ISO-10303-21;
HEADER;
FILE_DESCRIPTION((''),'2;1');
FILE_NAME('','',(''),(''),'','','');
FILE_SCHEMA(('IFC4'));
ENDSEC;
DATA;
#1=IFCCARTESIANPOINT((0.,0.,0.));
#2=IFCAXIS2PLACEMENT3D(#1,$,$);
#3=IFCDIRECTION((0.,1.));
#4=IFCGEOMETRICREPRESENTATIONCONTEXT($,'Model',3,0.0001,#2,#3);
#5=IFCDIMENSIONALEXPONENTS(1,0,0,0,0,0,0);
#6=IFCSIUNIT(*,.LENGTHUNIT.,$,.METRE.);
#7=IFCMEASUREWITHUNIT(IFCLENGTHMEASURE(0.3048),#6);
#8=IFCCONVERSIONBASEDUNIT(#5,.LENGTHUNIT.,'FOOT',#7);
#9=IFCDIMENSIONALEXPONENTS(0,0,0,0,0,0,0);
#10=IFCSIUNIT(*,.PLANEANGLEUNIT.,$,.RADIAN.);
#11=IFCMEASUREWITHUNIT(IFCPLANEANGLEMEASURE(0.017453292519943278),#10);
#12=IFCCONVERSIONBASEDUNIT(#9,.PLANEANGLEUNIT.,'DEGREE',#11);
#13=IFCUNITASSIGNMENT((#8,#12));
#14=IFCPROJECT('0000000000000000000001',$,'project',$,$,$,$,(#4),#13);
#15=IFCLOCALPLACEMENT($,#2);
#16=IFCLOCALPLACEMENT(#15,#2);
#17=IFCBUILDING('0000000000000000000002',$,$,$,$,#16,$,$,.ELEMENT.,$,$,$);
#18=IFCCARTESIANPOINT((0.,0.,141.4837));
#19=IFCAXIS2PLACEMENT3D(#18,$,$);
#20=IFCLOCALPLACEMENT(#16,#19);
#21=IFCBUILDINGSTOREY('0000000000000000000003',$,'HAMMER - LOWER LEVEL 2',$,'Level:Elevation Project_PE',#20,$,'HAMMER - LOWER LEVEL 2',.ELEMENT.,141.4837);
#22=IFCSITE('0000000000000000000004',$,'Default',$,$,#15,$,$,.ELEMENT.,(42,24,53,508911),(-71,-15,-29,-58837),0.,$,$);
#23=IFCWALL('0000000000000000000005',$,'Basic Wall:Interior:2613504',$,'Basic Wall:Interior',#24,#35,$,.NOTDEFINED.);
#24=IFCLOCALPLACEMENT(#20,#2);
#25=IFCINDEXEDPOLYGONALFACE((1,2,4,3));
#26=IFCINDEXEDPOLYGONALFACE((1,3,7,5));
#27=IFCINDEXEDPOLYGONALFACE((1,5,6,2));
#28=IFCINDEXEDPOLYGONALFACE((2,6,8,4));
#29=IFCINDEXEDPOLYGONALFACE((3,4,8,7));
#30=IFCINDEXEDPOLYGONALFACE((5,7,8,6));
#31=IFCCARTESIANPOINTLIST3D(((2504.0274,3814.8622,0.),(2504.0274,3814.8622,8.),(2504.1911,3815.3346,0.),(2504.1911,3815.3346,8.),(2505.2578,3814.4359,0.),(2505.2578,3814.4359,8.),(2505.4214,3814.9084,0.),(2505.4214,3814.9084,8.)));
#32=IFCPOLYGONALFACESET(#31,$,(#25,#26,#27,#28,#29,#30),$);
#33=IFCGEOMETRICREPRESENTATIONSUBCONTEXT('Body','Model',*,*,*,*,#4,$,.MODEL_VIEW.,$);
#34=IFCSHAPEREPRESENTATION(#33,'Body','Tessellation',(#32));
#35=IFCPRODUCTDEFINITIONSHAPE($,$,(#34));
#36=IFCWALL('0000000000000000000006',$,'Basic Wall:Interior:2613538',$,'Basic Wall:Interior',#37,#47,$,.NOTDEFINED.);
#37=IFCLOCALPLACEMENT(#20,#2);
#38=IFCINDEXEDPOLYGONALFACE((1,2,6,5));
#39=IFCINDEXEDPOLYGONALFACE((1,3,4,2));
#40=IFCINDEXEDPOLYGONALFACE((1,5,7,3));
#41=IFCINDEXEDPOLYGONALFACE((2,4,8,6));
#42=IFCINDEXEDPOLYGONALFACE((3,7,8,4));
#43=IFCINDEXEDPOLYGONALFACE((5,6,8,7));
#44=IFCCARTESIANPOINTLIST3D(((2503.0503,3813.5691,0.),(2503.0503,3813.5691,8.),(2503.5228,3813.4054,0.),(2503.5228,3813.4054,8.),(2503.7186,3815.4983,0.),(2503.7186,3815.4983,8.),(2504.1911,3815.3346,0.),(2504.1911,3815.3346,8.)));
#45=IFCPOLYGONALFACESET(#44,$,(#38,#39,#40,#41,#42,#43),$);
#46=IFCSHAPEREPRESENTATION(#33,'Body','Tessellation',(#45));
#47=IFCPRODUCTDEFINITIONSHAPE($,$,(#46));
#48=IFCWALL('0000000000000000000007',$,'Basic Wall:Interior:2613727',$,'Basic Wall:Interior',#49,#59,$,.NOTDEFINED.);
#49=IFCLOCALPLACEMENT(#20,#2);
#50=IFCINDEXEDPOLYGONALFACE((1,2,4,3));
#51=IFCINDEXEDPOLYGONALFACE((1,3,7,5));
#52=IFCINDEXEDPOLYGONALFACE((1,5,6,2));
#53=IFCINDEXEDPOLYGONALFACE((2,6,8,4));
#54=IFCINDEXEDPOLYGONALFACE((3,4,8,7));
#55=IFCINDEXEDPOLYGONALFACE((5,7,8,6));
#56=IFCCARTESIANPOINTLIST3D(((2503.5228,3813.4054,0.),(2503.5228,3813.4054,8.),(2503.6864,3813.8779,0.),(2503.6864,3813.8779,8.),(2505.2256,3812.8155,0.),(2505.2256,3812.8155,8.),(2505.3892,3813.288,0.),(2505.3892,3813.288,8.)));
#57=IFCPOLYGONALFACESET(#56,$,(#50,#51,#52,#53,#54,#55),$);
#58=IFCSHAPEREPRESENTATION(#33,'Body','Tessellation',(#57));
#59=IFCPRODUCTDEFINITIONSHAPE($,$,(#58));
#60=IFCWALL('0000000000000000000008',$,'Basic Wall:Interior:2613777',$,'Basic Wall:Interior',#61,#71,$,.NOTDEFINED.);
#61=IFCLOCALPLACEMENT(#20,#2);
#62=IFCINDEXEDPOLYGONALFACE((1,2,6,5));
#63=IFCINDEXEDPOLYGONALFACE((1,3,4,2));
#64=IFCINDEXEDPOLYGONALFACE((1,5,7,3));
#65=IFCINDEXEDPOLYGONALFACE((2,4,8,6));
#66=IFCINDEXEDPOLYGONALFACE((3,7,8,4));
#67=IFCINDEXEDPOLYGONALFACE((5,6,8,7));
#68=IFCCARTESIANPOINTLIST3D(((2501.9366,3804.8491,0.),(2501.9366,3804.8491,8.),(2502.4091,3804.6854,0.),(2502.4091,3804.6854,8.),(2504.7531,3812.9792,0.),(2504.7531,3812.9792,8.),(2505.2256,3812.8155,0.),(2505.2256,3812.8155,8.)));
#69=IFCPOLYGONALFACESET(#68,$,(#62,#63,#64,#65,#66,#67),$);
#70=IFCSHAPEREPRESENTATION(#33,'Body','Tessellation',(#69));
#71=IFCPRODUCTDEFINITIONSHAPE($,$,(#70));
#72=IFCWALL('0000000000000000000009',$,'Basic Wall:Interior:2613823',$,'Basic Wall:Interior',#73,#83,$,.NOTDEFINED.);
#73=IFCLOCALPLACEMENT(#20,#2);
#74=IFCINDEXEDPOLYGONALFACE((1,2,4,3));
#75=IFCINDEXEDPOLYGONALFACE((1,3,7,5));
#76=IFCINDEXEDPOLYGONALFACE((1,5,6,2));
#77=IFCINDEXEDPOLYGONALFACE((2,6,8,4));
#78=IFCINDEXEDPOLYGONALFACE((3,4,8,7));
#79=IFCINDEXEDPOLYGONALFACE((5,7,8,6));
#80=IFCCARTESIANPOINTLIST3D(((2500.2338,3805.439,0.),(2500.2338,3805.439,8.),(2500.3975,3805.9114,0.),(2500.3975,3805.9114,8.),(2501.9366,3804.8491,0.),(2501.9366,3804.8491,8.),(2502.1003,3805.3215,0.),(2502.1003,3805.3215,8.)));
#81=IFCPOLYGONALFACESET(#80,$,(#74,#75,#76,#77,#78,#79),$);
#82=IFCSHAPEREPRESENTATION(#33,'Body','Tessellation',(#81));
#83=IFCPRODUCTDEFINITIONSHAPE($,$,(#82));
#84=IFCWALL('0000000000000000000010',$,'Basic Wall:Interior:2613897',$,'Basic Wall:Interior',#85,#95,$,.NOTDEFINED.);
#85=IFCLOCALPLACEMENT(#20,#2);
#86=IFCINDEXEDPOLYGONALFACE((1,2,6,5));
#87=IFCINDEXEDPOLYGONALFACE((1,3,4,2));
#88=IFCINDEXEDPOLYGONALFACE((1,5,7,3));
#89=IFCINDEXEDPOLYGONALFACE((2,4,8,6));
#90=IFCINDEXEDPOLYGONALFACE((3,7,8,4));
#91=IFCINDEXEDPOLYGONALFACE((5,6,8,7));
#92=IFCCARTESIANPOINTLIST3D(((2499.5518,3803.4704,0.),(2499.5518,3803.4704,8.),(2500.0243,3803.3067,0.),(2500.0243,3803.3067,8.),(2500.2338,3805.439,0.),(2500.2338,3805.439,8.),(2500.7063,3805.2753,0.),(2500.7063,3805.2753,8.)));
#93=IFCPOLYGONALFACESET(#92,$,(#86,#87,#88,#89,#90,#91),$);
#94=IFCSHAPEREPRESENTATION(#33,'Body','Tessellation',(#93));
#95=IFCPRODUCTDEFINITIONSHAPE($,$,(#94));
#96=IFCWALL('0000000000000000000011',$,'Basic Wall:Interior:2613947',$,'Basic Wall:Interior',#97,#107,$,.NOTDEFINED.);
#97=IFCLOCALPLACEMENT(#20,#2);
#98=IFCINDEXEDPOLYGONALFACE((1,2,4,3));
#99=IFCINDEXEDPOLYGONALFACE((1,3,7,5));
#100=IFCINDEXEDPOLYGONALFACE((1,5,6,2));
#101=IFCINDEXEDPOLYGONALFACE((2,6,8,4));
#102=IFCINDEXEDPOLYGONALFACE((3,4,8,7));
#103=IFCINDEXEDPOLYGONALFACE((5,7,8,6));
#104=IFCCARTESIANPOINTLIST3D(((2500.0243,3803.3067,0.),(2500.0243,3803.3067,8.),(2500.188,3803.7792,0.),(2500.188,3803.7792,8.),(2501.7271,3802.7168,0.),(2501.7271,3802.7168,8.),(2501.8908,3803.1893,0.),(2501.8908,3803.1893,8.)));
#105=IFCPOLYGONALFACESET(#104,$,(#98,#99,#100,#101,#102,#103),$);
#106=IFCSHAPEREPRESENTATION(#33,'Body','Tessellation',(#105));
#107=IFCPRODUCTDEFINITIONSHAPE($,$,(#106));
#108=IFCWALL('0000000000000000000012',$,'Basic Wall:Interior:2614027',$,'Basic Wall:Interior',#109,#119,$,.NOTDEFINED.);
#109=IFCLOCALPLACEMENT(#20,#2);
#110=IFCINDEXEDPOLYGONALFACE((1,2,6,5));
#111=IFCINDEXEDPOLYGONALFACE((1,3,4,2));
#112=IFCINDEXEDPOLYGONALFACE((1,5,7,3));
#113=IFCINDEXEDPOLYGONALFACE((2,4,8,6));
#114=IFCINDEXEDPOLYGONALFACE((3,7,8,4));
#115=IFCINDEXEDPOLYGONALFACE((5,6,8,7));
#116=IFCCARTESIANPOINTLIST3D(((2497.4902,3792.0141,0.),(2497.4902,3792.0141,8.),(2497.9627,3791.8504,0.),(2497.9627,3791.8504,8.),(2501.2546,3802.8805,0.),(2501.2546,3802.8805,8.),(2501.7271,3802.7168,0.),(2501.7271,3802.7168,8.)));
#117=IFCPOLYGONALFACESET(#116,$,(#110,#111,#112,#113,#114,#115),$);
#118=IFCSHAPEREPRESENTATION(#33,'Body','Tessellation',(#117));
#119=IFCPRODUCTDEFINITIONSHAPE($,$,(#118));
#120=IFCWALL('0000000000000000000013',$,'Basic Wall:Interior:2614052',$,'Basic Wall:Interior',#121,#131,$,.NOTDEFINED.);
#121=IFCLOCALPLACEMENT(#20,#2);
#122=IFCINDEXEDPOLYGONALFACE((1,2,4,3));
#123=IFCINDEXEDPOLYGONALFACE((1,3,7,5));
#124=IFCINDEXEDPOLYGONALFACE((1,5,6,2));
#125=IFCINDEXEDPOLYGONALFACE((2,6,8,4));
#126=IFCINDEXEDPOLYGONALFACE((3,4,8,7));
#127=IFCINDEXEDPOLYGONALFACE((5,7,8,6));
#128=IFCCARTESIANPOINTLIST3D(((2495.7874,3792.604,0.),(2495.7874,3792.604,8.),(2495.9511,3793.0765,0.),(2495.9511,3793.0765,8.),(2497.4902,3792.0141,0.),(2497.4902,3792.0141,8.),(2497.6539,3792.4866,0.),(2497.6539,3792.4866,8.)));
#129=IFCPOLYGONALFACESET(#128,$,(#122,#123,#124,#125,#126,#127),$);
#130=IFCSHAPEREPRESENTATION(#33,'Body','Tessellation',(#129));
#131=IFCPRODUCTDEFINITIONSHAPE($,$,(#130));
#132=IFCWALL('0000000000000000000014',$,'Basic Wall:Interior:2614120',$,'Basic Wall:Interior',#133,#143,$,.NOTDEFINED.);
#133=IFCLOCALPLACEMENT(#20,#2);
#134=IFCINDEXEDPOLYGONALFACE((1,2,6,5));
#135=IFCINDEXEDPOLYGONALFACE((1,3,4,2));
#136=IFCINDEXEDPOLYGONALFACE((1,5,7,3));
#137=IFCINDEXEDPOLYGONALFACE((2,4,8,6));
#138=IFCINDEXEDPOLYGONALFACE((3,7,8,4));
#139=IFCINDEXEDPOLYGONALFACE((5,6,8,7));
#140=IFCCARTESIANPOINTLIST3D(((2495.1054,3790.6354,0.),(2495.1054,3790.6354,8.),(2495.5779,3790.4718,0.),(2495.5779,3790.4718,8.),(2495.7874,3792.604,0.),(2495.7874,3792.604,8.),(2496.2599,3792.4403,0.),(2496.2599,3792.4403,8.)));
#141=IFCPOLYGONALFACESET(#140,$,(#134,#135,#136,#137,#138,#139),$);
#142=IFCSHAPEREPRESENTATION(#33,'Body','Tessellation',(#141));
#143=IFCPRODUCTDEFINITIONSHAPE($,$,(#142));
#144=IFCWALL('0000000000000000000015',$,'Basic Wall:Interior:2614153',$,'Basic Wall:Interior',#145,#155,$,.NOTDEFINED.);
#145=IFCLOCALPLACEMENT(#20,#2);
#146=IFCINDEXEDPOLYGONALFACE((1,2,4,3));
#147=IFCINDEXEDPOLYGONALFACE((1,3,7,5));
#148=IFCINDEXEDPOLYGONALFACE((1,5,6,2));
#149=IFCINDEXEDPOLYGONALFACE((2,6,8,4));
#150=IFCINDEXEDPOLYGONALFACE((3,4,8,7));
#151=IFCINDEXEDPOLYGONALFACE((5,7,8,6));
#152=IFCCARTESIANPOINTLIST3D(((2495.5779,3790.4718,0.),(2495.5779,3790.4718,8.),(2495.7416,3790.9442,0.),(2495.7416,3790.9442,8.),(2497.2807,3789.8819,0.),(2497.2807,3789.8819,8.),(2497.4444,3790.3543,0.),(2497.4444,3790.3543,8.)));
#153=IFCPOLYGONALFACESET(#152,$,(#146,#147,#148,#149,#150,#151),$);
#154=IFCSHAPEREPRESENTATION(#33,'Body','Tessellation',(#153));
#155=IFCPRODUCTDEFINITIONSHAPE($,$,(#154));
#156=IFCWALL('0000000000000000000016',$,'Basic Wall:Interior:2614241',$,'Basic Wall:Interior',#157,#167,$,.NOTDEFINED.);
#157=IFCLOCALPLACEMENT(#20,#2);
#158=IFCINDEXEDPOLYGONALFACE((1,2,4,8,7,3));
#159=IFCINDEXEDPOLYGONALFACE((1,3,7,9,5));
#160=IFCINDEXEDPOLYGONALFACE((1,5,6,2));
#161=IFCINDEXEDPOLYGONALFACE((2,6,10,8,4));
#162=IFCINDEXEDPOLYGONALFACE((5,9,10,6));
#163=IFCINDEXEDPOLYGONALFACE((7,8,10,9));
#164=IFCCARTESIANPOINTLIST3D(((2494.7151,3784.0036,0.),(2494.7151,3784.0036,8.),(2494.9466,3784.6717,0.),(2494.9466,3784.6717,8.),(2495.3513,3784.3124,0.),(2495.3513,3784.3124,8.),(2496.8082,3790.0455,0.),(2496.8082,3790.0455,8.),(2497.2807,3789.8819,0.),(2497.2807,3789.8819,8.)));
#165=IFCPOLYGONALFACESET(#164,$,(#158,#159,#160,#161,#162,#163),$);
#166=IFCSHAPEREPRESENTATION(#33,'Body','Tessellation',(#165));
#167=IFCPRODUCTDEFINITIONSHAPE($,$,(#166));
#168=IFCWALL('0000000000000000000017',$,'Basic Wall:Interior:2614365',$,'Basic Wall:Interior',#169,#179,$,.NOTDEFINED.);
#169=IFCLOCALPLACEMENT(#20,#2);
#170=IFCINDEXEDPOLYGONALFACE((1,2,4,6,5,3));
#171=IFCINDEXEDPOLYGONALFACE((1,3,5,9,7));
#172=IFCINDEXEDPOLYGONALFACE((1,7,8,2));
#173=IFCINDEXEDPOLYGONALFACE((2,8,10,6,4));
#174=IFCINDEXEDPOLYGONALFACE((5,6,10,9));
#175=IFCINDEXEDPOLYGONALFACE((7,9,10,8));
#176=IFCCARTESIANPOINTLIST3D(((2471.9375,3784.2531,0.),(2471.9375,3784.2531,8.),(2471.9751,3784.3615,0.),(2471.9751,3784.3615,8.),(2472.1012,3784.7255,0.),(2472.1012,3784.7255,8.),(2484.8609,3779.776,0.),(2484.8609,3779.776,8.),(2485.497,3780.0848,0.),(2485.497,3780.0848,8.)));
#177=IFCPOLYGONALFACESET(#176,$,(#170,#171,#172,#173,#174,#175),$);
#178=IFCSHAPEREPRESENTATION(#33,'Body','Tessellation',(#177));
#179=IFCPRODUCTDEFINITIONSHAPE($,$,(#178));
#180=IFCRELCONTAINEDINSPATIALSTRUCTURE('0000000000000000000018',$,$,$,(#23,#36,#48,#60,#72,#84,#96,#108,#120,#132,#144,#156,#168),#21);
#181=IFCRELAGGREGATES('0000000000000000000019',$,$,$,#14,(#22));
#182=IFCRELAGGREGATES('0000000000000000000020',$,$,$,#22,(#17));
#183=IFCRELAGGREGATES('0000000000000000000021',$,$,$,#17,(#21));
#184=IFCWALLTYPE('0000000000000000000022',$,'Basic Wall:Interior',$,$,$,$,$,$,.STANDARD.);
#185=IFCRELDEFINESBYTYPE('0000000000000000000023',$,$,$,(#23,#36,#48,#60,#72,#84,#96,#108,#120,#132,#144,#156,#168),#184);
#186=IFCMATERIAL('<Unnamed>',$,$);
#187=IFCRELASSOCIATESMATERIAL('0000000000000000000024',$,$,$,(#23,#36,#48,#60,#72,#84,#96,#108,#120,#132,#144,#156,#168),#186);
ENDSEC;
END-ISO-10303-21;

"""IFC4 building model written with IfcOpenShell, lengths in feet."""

from ifc_helpers import new_model, entity, si_unit, converted_unit, direction, frame, origin, place, context, subcontext, project, spatial, indexed_curve, outline, extrude, material, type_object, element, save


model = new_model("IFC4")

# Units and contexts
model_context = context("Model", 3, precision=0.0001, world=origin(), true_north=direction((0.0, 1.0)))
body_context = subcontext(model_context, "Body", "Model", "MODEL_VIEW")
ifc_project = project(units=[converted_unit("LENGTHUNIT", "FOOT", entity("IfcLengthMeasure", 0.3048), si_unit("LENGTHUNIT", "METRE"), dimensions=[1, 0, 0, 0, 0, 0, 0]), converted_unit("PLANEANGLEUNIT", "DEGREE", entity("IfcPlaneAngleMeasure", 0.017453292519943278), si_unit("PLANEANGLEUNIT", "RADIAN"), dimensions=[0, 0, 0, 0, 0, 0, 0])], contexts=[model_context])

# Site, building, storey
site_placement = place(None, origin())
site = spatial("IfcSite", under=ifc_project, at=site_placement, Name="Default", CompositionType="ELEMENT", RefLatitude=(42, 24, 53, 508911), RefLongitude=(-71, -15, -29, -58837), RefElevation=0.0)
building_placement = place(site_placement, origin())
building = spatial("IfcBuilding", under=site, at=building_placement, CompositionType="ELEMENT")
storey_placement = place(building_placement, frame((0.0, 0.0, 141.4837)))
storey = spatial("IfcBuildingStorey", under=building, at=storey_placement, Name="HAMMER - LOWER LEVEL 2", ObjectType="Level:Elevation Project_PE", LongName="HAMMER - LOWER LEVEL 2", CompositionType="ELEMENT", Elevation=141.4837)

# Shared definitions
ifc_material_1 = material(Name="<Unnamed>")
wall_type = type_object("IfcWallType", Name="Basic Wall:Interior", PredefinedType="STANDARD")

# Walls
wall_1_placement = place(storey_placement, frame((2505.3396, 3814.6722, 0.0), z_axis=(0.0, 0.0, 1.0), x_axis=(-0.944906, 0.327342, 0.0)))
element("IfcWall", 1, at=wall_1_placement, inside=storey, type_object=wall_type, material=ifc_material_1, Name="Basic Wall:Interior:2613504", ObjectType="Basic Wall:Interior", PredefinedType="NOTDEFINED", context=body_context, shape_type="SweptSolid", body=[
    extrude(outline(indexed_curve([(1.3021, 0.25), (0.0, 0.25), (0.0, -0.25), (1.3021, -0.25), (1.3021, 0.25)], self_intersect=False)), origin(), (0.0, 0.0, 1.0), 8.0),
])
wall_2_placement = place(storey_placement, frame((2503.9549, 3815.4164, 0.0), z_axis=(0.0, 0.0, 1.0), x_axis=(-0.327342, -0.944906, 0.0)))
element("IfcWall", 2, at=wall_2_placement, inside=storey, type_object=wall_type, material=ifc_material_1, Name="Basic Wall:Interior:2613538", ObjectType="Basic Wall:Interior", PredefinedType="NOTDEFINED", context=body_context, shape_type="SweptSolid", body=[
    extrude(outline(indexed_curve([(2.0417, 0.25), (0.0, 0.25), (0.0, -0.25), (2.0417, -0.25), (2.0417, 0.25)], self_intersect=False)), origin(), (0.0, 0.0, 1.0), 8.0),
])
wall_3_placement = place(storey_placement, frame((2503.6046, 3813.6417, 0.0), z_axis=(0.0, 0.0, 1.0), x_axis=(0.944906, -0.327342, 0.0)))
element("IfcWall", 3, at=wall_3_placement, inside=storey, type_object=wall_type, material=ifc_material_1, Name="Basic Wall:Interior:2613727", ObjectType="Basic Wall:Interior", PredefinedType="NOTDEFINED", context=body_context, shape_type="SweptSolid", body=[
    extrude(outline(indexed_curve([(1.8021, 0.25), (0.0, 0.25), (0.0, -0.25), (1.8021, -0.25), (1.8021, 0.25)], self_intersect=False)), origin(), (0.0, 0.0, 1.0), 8.0),
])
wall_4_placement = place(storey_placement, frame((2504.9893, 3812.8974, 0.0), z_axis=(0.0, 0.0, 1.0), x_axis=(-0.327342, -0.944906, 0.0)))
element("IfcWall", 4, at=wall_4_placement, inside=storey, type_object=wall_type, material=ifc_material_1, Name="Basic Wall:Interior:2613777", ObjectType="Basic Wall:Interior", PredefinedType="NOTDEFINED", context=body_context, shape_type="SweptSolid", body=[
    extrude(outline(indexed_curve([(8.6042, 0.25), (0.0, 0.25), (0.0, -0.25), (8.6042, -0.25), (8.6042, 0.25)], self_intersect=False)), origin(), (0.0, 0.0, 1.0), 8.0),
])
wall_5_placement = place(storey_placement, frame((2502.0184, 3805.0853, 0.0), z_axis=(0.0, 0.0, 1.0), x_axis=(-0.944906, 0.327342, 0.0)))
element("IfcWall", 5, at=wall_5_placement, inside=storey, type_object=wall_type, material=ifc_material_1, Name="Basic Wall:Interior:2613823", ObjectType="Basic Wall:Interior", PredefinedType="NOTDEFINED", context=body_context, shape_type="SweptSolid", body=[
    extrude(outline(indexed_curve([(1.8021, 0.25), (0.0, 0.25), (0.0, -0.25), (1.8021, -0.25), (1.8021, 0.25)], self_intersect=False)), origin(), (0.0, 0.0, 1.0), 8.0),
])
wall_6_placement = place(storey_placement, frame((2500.47, 3805.3571, 0.0), z_axis=(0.0, 0.0, 1.0), x_axis=(-0.327342, -0.944906, 0.0)))
element("IfcWall", 6, at=wall_6_placement, inside=storey, type_object=wall_type, material=ifc_material_1, Name="Basic Wall:Interior:2613897", ObjectType="Basic Wall:Interior", PredefinedType="NOTDEFINED", context=body_context, shape_type="SweptSolid", body=[
    extrude(outline(indexed_curve([(2.0833, 0.25), (0.0, 0.25), (0.0, -0.25), (2.0833, -0.25), (2.0833, 0.25)], self_intersect=False)), origin(), (0.0, 0.0, 1.0), 8.0),
])
wall_7_placement = place(storey_placement, frame((2500.1061, 3803.543, 0.0), z_axis=(0.0, 0.0, 1.0), x_axis=(0.944906, -0.327342, 0.0)))
element("IfcWall", 7, at=wall_7_placement, inside=storey, type_object=wall_type, material=ifc_material_1, Name="Basic Wall:Interior:2613947", ObjectType="Basic Wall:Interior", PredefinedType="NOTDEFINED", context=body_context, shape_type="SweptSolid", body=[
    extrude(outline(indexed_curve([(1.8021, 0.25), (0.0, 0.25), (0.0, -0.25), (1.8021, -0.25), (1.8021, 0.25)], self_intersect=False)), origin(), (0.0, 0.0, 1.0), 8.0),
])
wall_8_placement = place(storey_placement, frame((2501.4909, 3802.7987, 0.0), z_axis=(0.0, 0.0, 1.0), x_axis=(-0.327342, -0.944906, 0.0)))
element("IfcWall", 8, at=wall_8_placement, inside=storey, type_object=wall_type, material=ifc_material_1, Name="Basic Wall:Interior:2614027", ObjectType="Basic Wall:Interior", PredefinedType="NOTDEFINED", context=body_context, shape_type="SweptSolid", body=[
    extrude(outline(indexed_curve([(11.5, 0.25), (0.0, 0.25), (0.0, -0.25), (11.5, -0.25), (11.5, 0.25)], self_intersect=False)), origin(), (0.0, 0.0, 1.0), 8.0),
])
wall_9_placement = place(storey_placement, frame((2497.572, 3792.2503, 0.0), z_axis=(0.0, 0.0, 1.0), x_axis=(-0.944906, 0.327342, 0.0)))
element("IfcWall", 9, at=wall_9_placement, inside=storey, type_object=wall_type, material=ifc_material_1, Name="Basic Wall:Interior:2614052", ObjectType="Basic Wall:Interior", PredefinedType="NOTDEFINED", context=body_context, shape_type="SweptSolid", body=[
    extrude(outline(indexed_curve([(1.8021, 0.25), (0.0, 0.25), (0.0, -0.25), (1.8021, -0.25), (1.8021, 0.25)], self_intersect=False)), origin(), (0.0, 0.0, 1.0), 8.0),
])
wall_10_placement = place(storey_placement, frame((2496.0236, 3792.5222, 0.0), z_axis=(0.0, 0.0, 1.0), x_axis=(-0.327342, -0.944906, 0.0)))
element("IfcWall", 10, at=wall_10_placement, inside=storey, type_object=wall_type, material=ifc_material_1, Name="Basic Wall:Interior:2614120", ObjectType="Basic Wall:Interior", PredefinedType="NOTDEFINED", context=body_context, shape_type="SweptSolid", body=[
    extrude(outline(indexed_curve([(2.0833, 0.25), (0.0, 0.25), (0.0, -0.25), (2.0833, -0.25), (2.0833, 0.25)], self_intersect=False)), origin(), (0.0, 0.0, 1.0), 8.0),
])
wall_11_placement = place(storey_placement, frame((2495.6597, 3790.708, 0.0), z_axis=(0.0, 0.0, 1.0), x_axis=(0.944906, -0.327342, 0.0)))
element("IfcWall", 11, at=wall_11_placement, inside=storey, type_object=wall_type, material=ifc_material_1, Name="Basic Wall:Interior:2614153", ObjectType="Basic Wall:Interior", PredefinedType="NOTDEFINED", context=body_context, shape_type="SweptSolid", body=[
    extrude(outline(indexed_curve([(1.8021, 0.25), (0.0, 0.25), (0.0, -0.25), (1.8021, -0.25), (1.8021, 0.25)], self_intersect=False)), origin(), (0.0, 0.0, 1.0), 8.0),
])
wall_12_placement = place(storey_placement, frame((2497.0445, 3789.9637, 0.0), z_axis=(0.0, 0.0, 1.0), x_axis=(-0.327342, -0.944906, 0.0)))
element("IfcWall", 12, at=wall_12_placement, inside=storey, type_object=wall_type, material=ifc_material_1, Name="Basic Wall:Interior:2614241", ObjectType="Basic Wall:Interior", PredefinedType="NOTDEFINED", context=body_context, shape_type="SweptSolid", body=[
    extrude(outline(indexed_curve([(6.3942, -0.25), (5.8942, 0.25), (0.0, 0.25), (0.0, -0.25), (5.6871, -0.25), (6.3942, -0.25)], self_intersect=False)), origin(), (0.0, 0.0, 1.0), 8.0),
])
wall_13_placement = place(storey_placement, frame((2485.4152, 3779.8486, 0.0), z_axis=(0.0, 0.0, 1.0), x_axis=(-0.944906, 0.327342, 0.0)))
element("IfcWall", 13, at=wall_13_placement, inside=storey, type_object=wall_type, material=ifc_material_1, Name="Basic Wall:Interior:2614365", ObjectType="Basic Wall:Interior", PredefinedType="NOTDEFINED", context=body_context, shape_type="SweptSolid", body=[
    extrude(outline(indexed_curve([(14.1769, -0.25), (14.1769, 0.1352), (14.1769, 0.25), (0.5, 0.25), (0.0, -0.25), (14.1769, -0.25)], self_intersect=False)), origin(), (0.0, 0.0, 1.0), 8.0),
])

save(model, "model.ifc")
